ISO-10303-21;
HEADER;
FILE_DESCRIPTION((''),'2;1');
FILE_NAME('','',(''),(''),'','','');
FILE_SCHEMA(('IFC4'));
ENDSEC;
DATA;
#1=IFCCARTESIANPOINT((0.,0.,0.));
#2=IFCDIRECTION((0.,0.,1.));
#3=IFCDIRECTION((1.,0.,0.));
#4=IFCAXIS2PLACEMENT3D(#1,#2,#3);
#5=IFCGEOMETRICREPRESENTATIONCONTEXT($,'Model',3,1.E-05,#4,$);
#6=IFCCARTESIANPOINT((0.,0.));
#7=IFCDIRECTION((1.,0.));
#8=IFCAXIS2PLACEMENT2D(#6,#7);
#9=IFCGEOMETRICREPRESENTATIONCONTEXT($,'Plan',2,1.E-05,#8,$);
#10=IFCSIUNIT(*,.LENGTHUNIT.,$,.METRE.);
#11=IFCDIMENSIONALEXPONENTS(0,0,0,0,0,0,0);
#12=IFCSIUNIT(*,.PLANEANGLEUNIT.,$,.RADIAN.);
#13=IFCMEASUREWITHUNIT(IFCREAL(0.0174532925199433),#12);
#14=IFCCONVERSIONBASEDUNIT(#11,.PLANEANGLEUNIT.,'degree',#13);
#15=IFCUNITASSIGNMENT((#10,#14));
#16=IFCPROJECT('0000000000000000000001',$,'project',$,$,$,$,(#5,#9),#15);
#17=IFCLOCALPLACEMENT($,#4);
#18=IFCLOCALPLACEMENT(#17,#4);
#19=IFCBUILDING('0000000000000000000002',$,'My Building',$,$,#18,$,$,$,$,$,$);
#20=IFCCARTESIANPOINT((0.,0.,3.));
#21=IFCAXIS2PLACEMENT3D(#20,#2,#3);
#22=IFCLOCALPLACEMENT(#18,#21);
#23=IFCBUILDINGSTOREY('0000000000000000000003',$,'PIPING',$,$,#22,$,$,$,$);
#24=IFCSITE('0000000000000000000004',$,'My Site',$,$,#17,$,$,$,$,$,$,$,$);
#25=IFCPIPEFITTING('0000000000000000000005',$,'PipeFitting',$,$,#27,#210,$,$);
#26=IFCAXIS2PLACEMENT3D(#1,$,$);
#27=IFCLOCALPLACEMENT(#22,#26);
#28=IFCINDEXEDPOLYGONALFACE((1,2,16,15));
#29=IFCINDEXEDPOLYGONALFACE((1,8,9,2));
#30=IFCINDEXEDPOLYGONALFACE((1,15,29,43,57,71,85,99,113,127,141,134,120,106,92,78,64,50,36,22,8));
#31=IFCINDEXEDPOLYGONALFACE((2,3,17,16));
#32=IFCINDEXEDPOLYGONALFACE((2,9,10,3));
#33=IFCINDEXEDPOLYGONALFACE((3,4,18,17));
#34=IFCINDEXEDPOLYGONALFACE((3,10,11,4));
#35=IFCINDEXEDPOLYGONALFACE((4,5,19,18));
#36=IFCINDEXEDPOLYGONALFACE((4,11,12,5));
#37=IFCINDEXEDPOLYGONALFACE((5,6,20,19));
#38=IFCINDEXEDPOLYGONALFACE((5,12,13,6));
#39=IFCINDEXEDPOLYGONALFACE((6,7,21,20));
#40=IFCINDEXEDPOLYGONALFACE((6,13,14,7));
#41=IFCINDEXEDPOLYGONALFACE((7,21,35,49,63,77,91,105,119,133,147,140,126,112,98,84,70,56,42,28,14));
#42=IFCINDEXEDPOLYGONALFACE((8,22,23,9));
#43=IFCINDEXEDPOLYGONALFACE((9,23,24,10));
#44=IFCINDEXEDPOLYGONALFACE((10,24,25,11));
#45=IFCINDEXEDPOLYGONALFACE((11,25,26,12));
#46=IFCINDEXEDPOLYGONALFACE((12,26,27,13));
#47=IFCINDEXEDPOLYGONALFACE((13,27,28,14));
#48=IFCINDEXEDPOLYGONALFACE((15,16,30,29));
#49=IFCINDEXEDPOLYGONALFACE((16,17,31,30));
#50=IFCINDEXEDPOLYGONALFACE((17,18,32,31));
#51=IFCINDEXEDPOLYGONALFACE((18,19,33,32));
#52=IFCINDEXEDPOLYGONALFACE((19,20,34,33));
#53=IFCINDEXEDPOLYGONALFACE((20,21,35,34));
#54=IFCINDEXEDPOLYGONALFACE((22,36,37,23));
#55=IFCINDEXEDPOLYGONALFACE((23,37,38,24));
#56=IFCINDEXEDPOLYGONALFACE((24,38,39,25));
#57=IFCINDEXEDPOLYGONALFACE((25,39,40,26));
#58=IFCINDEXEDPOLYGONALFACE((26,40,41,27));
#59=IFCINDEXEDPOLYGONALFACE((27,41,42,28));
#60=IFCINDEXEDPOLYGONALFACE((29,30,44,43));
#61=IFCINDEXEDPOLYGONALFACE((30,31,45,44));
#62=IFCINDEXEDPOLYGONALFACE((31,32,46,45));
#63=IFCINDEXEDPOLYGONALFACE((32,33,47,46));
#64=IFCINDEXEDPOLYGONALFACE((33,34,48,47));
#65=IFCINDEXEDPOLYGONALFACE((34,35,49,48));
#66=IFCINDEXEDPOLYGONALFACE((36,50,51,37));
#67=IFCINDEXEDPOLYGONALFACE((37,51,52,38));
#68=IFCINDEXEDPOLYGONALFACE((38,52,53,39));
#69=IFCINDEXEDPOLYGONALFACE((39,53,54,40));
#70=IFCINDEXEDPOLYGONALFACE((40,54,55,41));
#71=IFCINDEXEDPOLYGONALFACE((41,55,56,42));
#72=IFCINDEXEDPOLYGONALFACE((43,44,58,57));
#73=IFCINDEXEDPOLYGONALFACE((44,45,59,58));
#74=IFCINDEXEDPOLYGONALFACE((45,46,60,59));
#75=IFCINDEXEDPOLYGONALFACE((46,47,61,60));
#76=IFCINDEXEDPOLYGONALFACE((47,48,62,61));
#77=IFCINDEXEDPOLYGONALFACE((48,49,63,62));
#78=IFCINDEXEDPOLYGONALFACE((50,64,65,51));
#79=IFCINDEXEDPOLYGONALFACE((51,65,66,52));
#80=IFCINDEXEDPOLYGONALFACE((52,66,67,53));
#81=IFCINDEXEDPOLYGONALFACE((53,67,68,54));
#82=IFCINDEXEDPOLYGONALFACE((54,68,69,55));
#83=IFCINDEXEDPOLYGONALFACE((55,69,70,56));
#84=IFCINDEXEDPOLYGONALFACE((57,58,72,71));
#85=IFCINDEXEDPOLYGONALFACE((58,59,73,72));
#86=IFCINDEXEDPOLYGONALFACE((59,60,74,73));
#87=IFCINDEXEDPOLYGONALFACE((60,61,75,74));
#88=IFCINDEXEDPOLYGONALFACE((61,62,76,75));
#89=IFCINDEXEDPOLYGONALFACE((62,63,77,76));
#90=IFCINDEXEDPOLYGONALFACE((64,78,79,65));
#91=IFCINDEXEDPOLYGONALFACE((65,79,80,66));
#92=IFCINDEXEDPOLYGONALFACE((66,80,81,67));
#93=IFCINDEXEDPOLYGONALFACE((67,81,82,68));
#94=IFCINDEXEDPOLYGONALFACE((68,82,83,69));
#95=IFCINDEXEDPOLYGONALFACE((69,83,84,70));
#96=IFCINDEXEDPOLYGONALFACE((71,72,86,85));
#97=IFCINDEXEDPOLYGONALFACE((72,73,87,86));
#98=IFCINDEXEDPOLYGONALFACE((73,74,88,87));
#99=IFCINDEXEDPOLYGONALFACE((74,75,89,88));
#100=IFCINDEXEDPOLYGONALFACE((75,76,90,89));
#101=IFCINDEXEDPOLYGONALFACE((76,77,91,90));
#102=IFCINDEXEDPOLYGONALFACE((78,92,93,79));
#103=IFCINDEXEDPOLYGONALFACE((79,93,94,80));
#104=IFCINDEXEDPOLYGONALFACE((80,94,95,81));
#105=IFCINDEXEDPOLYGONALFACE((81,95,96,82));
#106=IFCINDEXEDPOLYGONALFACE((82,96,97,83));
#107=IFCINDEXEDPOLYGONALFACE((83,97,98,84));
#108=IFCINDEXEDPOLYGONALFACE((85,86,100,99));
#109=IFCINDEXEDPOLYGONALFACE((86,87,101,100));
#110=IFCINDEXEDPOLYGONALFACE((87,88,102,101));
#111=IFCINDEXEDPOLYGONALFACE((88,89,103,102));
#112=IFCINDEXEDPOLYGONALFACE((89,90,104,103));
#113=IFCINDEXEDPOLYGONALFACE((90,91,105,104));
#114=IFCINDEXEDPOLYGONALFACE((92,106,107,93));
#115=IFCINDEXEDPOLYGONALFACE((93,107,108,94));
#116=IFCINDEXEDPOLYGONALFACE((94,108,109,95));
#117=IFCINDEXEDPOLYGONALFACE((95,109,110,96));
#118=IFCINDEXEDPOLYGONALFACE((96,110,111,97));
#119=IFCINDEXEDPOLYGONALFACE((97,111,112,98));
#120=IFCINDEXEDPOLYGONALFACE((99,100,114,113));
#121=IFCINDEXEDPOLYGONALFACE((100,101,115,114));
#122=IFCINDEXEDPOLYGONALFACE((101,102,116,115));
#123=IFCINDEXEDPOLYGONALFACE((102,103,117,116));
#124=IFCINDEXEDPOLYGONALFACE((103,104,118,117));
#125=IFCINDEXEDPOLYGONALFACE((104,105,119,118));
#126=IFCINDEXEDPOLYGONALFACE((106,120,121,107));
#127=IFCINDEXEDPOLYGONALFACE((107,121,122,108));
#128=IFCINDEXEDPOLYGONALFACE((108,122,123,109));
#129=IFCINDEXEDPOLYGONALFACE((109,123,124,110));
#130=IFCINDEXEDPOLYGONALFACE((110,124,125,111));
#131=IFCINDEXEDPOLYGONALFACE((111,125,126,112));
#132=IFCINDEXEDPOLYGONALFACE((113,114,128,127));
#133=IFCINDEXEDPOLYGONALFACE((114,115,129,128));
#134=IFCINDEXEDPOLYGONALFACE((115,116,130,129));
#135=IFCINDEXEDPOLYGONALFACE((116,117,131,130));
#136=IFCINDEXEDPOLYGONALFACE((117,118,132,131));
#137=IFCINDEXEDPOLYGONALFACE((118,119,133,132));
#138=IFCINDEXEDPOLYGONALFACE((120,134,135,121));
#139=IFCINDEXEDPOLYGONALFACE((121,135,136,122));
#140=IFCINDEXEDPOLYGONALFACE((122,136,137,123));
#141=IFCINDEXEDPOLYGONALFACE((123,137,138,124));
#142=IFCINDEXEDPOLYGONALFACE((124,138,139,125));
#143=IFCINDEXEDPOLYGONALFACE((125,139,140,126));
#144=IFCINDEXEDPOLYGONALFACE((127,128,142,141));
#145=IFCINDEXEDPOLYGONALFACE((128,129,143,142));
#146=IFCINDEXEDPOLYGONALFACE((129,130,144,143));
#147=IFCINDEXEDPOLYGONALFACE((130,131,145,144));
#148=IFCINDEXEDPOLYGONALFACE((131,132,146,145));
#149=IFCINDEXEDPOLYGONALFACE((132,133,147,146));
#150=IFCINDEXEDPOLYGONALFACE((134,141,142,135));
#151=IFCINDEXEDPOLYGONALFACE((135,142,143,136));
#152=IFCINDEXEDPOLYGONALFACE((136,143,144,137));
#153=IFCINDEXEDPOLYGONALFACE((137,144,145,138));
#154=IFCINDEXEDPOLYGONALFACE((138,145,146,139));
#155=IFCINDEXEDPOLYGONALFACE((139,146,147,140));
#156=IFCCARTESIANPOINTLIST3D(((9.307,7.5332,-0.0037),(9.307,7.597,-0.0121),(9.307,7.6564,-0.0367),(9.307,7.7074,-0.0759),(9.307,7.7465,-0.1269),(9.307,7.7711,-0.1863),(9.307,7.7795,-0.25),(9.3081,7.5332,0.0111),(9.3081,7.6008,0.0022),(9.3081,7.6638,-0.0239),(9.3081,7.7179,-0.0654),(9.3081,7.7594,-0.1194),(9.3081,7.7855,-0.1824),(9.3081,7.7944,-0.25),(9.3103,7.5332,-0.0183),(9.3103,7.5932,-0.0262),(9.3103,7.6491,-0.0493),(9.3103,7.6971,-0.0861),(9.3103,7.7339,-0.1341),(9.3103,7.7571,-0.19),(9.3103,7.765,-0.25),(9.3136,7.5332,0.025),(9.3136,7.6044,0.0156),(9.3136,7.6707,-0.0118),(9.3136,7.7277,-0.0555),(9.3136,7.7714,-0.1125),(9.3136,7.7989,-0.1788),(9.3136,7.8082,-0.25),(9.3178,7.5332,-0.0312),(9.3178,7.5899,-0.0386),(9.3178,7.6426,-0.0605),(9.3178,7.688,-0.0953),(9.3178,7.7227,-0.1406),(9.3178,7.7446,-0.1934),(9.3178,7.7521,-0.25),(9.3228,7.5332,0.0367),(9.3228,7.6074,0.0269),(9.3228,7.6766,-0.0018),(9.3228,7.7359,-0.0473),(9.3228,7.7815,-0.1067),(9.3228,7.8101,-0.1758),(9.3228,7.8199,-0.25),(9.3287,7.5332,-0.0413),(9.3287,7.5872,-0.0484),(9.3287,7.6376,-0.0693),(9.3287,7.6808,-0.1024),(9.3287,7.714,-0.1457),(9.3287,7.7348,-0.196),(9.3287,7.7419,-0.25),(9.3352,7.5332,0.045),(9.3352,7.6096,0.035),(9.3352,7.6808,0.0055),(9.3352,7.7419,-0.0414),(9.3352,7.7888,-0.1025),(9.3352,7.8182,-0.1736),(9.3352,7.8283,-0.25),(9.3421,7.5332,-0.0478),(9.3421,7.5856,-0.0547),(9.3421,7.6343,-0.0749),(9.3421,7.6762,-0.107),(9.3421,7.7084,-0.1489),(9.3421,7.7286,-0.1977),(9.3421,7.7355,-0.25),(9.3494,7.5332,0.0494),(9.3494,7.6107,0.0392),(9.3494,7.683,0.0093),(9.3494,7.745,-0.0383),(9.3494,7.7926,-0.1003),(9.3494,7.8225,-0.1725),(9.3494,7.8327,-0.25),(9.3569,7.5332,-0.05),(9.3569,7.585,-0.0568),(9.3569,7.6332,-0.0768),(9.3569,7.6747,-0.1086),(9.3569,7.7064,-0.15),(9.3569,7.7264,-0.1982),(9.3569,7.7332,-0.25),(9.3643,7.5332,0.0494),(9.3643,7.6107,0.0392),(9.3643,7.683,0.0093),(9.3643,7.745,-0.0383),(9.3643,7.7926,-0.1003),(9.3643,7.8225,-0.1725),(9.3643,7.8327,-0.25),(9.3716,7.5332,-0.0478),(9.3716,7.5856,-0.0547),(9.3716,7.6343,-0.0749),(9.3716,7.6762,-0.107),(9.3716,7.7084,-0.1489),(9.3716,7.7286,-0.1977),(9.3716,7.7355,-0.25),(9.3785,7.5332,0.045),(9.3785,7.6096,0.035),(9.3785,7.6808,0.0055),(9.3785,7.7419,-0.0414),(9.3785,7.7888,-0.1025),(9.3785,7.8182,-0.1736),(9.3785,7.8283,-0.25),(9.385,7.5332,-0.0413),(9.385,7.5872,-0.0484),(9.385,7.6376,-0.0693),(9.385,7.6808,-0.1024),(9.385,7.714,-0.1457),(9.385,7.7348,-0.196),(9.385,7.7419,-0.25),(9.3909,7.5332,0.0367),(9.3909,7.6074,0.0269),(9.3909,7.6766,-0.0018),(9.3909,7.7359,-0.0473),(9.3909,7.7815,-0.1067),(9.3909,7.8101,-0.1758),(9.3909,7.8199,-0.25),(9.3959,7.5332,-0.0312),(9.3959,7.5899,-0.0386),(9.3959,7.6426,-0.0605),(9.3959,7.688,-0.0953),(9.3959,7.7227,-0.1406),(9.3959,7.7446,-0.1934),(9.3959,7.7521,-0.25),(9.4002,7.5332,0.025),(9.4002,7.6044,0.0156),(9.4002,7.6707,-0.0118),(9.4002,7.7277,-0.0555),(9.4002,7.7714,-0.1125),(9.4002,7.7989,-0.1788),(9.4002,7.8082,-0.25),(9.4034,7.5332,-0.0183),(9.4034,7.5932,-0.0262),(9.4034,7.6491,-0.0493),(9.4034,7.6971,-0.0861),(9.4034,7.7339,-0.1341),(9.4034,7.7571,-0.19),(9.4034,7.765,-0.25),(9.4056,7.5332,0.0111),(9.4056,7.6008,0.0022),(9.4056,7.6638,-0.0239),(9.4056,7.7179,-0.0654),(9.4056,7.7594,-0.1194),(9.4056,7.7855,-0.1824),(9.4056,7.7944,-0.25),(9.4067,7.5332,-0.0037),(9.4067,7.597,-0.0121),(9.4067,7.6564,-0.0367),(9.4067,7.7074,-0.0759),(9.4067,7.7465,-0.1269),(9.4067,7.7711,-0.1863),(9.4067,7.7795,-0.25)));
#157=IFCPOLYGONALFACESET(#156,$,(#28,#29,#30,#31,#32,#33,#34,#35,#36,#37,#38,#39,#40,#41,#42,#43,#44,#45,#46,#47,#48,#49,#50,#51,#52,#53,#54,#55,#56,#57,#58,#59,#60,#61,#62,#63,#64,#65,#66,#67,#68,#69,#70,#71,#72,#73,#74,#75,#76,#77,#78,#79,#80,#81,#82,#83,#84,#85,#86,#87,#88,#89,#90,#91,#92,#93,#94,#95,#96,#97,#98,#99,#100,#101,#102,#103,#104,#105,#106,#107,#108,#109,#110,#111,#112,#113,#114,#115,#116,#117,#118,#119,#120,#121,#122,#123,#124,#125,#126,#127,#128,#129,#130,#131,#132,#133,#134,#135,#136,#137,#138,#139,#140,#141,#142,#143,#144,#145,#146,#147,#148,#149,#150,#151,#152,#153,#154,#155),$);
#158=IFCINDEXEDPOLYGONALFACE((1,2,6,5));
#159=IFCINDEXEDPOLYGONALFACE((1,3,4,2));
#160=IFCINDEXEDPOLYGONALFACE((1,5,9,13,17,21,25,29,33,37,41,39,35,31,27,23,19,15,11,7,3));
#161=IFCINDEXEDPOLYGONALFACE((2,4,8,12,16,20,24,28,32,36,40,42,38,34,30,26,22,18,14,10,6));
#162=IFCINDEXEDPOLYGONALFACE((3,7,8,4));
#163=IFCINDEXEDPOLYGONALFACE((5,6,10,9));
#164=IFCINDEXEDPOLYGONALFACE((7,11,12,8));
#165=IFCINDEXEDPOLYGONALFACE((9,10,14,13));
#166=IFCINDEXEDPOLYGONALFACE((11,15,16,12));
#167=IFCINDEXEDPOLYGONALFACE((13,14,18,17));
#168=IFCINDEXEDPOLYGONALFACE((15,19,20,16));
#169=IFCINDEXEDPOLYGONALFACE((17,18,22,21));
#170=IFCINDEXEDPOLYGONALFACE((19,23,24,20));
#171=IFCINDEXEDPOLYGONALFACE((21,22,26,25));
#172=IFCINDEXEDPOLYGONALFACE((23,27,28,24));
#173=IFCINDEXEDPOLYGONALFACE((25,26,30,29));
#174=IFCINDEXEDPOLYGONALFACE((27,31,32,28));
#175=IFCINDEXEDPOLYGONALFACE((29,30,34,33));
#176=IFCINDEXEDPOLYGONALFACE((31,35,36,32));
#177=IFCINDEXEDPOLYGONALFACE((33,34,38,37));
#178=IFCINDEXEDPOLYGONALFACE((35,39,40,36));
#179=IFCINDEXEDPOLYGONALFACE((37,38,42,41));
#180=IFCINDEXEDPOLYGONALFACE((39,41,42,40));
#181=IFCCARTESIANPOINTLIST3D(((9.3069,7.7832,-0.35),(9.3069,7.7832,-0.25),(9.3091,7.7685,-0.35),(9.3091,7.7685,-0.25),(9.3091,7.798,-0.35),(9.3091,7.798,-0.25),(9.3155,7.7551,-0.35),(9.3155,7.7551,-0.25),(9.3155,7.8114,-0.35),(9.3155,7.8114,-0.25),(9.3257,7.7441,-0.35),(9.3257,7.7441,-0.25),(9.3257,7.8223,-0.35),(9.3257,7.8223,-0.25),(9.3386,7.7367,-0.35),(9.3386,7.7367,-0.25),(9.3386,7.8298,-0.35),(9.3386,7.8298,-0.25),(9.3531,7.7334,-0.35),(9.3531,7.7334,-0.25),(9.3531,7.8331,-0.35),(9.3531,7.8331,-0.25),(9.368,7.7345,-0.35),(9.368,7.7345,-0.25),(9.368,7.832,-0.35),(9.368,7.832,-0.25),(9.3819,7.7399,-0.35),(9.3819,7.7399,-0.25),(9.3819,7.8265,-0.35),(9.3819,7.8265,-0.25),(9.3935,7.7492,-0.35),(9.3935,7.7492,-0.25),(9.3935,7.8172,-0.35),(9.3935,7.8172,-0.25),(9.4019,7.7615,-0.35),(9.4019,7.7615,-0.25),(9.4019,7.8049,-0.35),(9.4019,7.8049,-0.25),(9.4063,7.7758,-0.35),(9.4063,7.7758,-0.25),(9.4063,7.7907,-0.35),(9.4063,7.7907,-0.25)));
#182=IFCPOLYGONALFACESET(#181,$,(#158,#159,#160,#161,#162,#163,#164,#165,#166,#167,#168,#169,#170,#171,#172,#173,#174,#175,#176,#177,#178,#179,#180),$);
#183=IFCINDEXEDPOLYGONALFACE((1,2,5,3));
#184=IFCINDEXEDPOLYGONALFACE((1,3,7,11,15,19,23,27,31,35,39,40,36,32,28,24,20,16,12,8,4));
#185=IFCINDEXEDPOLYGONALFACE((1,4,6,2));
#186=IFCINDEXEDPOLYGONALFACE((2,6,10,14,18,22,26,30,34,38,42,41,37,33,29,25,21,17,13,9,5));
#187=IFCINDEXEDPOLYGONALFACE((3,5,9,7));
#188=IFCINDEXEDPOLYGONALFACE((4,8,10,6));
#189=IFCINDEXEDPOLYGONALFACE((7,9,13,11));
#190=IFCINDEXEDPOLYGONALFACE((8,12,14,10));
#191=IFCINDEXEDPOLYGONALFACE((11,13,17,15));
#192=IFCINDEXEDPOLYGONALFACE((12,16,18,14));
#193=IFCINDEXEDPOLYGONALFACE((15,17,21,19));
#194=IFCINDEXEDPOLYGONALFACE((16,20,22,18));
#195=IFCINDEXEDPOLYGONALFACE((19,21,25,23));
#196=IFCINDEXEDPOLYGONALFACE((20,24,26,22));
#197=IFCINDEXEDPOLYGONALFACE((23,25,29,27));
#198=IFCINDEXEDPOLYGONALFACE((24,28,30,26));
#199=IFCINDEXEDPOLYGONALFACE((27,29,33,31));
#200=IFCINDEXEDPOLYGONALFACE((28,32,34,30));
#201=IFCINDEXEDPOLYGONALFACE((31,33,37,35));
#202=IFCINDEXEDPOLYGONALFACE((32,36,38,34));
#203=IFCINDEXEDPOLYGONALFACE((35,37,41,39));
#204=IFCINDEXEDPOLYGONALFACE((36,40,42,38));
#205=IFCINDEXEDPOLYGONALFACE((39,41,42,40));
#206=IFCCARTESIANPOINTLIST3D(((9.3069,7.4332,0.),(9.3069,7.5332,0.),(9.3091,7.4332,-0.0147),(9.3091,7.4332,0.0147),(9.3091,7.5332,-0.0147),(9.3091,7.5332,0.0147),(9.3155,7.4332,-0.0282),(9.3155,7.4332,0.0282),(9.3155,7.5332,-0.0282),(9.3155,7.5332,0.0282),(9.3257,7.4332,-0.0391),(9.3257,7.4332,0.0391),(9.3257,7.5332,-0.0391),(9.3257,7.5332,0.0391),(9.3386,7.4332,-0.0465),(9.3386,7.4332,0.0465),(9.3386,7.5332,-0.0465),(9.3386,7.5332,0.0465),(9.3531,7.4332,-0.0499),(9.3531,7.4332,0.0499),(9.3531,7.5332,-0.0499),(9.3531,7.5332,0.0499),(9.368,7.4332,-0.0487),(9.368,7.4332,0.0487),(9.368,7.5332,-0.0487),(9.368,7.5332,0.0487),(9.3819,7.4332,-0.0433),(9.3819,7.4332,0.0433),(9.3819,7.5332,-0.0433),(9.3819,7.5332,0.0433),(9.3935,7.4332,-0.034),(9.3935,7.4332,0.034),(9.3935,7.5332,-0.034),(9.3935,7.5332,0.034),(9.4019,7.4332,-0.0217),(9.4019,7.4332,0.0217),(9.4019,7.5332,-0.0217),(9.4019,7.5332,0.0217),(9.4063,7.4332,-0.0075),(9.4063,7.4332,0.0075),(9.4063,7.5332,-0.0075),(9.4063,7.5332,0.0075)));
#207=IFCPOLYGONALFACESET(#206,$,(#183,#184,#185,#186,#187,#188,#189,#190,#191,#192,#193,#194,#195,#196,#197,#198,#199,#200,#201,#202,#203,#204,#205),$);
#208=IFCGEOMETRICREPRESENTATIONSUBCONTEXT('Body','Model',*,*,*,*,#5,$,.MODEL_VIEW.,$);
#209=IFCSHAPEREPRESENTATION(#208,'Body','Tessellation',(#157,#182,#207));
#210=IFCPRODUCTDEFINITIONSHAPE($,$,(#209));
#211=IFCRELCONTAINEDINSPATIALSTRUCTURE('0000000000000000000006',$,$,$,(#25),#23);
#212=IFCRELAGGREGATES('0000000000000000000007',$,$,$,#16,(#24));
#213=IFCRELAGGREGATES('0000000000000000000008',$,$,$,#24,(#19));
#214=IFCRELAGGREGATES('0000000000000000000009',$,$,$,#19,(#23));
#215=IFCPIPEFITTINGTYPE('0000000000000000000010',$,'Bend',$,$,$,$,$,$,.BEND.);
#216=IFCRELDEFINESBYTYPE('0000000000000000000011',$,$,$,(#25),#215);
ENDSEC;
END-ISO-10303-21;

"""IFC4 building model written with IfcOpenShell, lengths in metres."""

from ifc_helpers import new_model, entity, si_unit, converted_unit, frame, origin_with_axes, origin_2d_with_axis, place, context, subcontext, project, spatial, circle, extrude, source, transform, mapped, type_object, type_shapes, element, save


model = new_model("IFC4")

# Units and contexts
model_context = context("Model", 3, precision=1e-05, world=origin_with_axes())
plan_context = context("Plan", 2, precision=1e-05, world=origin_2d_with_axis())
body_context = subcontext(model_context, "Body", "Model", "MODEL_VIEW")
ifc_project = project(units=[si_unit("LENGTHUNIT", "METRE"), converted_unit("PLANEANGLEUNIT", "degree", entity("IfcReal", 0.0174532925199433), si_unit("PLANEANGLEUNIT", "RADIAN"), dimensions=[0, 0, 0, 0, 0, 0, 0])], contexts=[model_context, plan_context])

# Site, building, storey
site_placement = place(None, origin_with_axes())
site = spatial("IfcSite", under=ifc_project, at=site_placement, Name="My Site")
building_placement = place(site_placement, origin_with_axes())
building = spatial("IfcBuilding", under=site, at=building_placement, Name="My Building")
storey_placement = place(building_placement, frame((0.0, 0.0, 3.0), z_axis=(0.0, 0.0, 1.0), x_axis=(1.0, 0.0, 0.0)))
storey = spatial("IfcBuildingStorey", under=building, at=storey_placement, Name="PIPING")

# Pipe fitting
pipe_fitting_type_1 = type_object("IfcPipeFittingType", Name="Bend", PredefinedType="BEND")
shared_shape = source(origin_with_axes(), body_context, "Body", "SolidModel", [
    entity("IfcSweptDiskSolid", entity("IfcIndexedPolyCurve", entity("IfcCartesianPointList3D", [[0.0, 0.0, -0.1], [0.0, -0.0732, -0.2768], [0.0, -0.25, -0.35]]), [entity("IfcArcIndex", [1, 2, 3])]), 0.05),
    extrude(circle(Radius=0.05), origin_with_axes(), (0.0, 0.0, -1.0), 0.1),
    extrude(circle(Radius=0.05), frame((0.0, -0.25, -0.35), z_axis=(0.0, -1.0, 0.0), x_axis=(1.0, 0.0, 0.0)), (0.0, 0.0, 1.0), 0.1),
])
type_shapes(pipe_fitting_type_1, [shared_shape])
for number, where, z_axis, x_axis, name in (
    (1, (9.3569, 7.7832, -0.35), (0.0, 0.0, -1.0), (-1.0, 0.0, 0.0), "PipeFitting"),
):
    element("IfcPipeFitting", number, at=place(storey_placement, frame(where, z_axis=z_axis, x_axis=x_axis)), inside=storey, type_object=pipe_fitting_type_1, Name=name, context=body_context, shape_type="MappedRepresentation", body=[
        mapped(shared_shape, transform((0.0, 0.0, 0.0), x_axis=(1.0, 0.0, 0.0), y_axis=(0.0, 1.0, 0.0), z_axis=(0.0, 0.0, 1.0), scale=1.0)),
    ])

save(model, "model.ifc")
